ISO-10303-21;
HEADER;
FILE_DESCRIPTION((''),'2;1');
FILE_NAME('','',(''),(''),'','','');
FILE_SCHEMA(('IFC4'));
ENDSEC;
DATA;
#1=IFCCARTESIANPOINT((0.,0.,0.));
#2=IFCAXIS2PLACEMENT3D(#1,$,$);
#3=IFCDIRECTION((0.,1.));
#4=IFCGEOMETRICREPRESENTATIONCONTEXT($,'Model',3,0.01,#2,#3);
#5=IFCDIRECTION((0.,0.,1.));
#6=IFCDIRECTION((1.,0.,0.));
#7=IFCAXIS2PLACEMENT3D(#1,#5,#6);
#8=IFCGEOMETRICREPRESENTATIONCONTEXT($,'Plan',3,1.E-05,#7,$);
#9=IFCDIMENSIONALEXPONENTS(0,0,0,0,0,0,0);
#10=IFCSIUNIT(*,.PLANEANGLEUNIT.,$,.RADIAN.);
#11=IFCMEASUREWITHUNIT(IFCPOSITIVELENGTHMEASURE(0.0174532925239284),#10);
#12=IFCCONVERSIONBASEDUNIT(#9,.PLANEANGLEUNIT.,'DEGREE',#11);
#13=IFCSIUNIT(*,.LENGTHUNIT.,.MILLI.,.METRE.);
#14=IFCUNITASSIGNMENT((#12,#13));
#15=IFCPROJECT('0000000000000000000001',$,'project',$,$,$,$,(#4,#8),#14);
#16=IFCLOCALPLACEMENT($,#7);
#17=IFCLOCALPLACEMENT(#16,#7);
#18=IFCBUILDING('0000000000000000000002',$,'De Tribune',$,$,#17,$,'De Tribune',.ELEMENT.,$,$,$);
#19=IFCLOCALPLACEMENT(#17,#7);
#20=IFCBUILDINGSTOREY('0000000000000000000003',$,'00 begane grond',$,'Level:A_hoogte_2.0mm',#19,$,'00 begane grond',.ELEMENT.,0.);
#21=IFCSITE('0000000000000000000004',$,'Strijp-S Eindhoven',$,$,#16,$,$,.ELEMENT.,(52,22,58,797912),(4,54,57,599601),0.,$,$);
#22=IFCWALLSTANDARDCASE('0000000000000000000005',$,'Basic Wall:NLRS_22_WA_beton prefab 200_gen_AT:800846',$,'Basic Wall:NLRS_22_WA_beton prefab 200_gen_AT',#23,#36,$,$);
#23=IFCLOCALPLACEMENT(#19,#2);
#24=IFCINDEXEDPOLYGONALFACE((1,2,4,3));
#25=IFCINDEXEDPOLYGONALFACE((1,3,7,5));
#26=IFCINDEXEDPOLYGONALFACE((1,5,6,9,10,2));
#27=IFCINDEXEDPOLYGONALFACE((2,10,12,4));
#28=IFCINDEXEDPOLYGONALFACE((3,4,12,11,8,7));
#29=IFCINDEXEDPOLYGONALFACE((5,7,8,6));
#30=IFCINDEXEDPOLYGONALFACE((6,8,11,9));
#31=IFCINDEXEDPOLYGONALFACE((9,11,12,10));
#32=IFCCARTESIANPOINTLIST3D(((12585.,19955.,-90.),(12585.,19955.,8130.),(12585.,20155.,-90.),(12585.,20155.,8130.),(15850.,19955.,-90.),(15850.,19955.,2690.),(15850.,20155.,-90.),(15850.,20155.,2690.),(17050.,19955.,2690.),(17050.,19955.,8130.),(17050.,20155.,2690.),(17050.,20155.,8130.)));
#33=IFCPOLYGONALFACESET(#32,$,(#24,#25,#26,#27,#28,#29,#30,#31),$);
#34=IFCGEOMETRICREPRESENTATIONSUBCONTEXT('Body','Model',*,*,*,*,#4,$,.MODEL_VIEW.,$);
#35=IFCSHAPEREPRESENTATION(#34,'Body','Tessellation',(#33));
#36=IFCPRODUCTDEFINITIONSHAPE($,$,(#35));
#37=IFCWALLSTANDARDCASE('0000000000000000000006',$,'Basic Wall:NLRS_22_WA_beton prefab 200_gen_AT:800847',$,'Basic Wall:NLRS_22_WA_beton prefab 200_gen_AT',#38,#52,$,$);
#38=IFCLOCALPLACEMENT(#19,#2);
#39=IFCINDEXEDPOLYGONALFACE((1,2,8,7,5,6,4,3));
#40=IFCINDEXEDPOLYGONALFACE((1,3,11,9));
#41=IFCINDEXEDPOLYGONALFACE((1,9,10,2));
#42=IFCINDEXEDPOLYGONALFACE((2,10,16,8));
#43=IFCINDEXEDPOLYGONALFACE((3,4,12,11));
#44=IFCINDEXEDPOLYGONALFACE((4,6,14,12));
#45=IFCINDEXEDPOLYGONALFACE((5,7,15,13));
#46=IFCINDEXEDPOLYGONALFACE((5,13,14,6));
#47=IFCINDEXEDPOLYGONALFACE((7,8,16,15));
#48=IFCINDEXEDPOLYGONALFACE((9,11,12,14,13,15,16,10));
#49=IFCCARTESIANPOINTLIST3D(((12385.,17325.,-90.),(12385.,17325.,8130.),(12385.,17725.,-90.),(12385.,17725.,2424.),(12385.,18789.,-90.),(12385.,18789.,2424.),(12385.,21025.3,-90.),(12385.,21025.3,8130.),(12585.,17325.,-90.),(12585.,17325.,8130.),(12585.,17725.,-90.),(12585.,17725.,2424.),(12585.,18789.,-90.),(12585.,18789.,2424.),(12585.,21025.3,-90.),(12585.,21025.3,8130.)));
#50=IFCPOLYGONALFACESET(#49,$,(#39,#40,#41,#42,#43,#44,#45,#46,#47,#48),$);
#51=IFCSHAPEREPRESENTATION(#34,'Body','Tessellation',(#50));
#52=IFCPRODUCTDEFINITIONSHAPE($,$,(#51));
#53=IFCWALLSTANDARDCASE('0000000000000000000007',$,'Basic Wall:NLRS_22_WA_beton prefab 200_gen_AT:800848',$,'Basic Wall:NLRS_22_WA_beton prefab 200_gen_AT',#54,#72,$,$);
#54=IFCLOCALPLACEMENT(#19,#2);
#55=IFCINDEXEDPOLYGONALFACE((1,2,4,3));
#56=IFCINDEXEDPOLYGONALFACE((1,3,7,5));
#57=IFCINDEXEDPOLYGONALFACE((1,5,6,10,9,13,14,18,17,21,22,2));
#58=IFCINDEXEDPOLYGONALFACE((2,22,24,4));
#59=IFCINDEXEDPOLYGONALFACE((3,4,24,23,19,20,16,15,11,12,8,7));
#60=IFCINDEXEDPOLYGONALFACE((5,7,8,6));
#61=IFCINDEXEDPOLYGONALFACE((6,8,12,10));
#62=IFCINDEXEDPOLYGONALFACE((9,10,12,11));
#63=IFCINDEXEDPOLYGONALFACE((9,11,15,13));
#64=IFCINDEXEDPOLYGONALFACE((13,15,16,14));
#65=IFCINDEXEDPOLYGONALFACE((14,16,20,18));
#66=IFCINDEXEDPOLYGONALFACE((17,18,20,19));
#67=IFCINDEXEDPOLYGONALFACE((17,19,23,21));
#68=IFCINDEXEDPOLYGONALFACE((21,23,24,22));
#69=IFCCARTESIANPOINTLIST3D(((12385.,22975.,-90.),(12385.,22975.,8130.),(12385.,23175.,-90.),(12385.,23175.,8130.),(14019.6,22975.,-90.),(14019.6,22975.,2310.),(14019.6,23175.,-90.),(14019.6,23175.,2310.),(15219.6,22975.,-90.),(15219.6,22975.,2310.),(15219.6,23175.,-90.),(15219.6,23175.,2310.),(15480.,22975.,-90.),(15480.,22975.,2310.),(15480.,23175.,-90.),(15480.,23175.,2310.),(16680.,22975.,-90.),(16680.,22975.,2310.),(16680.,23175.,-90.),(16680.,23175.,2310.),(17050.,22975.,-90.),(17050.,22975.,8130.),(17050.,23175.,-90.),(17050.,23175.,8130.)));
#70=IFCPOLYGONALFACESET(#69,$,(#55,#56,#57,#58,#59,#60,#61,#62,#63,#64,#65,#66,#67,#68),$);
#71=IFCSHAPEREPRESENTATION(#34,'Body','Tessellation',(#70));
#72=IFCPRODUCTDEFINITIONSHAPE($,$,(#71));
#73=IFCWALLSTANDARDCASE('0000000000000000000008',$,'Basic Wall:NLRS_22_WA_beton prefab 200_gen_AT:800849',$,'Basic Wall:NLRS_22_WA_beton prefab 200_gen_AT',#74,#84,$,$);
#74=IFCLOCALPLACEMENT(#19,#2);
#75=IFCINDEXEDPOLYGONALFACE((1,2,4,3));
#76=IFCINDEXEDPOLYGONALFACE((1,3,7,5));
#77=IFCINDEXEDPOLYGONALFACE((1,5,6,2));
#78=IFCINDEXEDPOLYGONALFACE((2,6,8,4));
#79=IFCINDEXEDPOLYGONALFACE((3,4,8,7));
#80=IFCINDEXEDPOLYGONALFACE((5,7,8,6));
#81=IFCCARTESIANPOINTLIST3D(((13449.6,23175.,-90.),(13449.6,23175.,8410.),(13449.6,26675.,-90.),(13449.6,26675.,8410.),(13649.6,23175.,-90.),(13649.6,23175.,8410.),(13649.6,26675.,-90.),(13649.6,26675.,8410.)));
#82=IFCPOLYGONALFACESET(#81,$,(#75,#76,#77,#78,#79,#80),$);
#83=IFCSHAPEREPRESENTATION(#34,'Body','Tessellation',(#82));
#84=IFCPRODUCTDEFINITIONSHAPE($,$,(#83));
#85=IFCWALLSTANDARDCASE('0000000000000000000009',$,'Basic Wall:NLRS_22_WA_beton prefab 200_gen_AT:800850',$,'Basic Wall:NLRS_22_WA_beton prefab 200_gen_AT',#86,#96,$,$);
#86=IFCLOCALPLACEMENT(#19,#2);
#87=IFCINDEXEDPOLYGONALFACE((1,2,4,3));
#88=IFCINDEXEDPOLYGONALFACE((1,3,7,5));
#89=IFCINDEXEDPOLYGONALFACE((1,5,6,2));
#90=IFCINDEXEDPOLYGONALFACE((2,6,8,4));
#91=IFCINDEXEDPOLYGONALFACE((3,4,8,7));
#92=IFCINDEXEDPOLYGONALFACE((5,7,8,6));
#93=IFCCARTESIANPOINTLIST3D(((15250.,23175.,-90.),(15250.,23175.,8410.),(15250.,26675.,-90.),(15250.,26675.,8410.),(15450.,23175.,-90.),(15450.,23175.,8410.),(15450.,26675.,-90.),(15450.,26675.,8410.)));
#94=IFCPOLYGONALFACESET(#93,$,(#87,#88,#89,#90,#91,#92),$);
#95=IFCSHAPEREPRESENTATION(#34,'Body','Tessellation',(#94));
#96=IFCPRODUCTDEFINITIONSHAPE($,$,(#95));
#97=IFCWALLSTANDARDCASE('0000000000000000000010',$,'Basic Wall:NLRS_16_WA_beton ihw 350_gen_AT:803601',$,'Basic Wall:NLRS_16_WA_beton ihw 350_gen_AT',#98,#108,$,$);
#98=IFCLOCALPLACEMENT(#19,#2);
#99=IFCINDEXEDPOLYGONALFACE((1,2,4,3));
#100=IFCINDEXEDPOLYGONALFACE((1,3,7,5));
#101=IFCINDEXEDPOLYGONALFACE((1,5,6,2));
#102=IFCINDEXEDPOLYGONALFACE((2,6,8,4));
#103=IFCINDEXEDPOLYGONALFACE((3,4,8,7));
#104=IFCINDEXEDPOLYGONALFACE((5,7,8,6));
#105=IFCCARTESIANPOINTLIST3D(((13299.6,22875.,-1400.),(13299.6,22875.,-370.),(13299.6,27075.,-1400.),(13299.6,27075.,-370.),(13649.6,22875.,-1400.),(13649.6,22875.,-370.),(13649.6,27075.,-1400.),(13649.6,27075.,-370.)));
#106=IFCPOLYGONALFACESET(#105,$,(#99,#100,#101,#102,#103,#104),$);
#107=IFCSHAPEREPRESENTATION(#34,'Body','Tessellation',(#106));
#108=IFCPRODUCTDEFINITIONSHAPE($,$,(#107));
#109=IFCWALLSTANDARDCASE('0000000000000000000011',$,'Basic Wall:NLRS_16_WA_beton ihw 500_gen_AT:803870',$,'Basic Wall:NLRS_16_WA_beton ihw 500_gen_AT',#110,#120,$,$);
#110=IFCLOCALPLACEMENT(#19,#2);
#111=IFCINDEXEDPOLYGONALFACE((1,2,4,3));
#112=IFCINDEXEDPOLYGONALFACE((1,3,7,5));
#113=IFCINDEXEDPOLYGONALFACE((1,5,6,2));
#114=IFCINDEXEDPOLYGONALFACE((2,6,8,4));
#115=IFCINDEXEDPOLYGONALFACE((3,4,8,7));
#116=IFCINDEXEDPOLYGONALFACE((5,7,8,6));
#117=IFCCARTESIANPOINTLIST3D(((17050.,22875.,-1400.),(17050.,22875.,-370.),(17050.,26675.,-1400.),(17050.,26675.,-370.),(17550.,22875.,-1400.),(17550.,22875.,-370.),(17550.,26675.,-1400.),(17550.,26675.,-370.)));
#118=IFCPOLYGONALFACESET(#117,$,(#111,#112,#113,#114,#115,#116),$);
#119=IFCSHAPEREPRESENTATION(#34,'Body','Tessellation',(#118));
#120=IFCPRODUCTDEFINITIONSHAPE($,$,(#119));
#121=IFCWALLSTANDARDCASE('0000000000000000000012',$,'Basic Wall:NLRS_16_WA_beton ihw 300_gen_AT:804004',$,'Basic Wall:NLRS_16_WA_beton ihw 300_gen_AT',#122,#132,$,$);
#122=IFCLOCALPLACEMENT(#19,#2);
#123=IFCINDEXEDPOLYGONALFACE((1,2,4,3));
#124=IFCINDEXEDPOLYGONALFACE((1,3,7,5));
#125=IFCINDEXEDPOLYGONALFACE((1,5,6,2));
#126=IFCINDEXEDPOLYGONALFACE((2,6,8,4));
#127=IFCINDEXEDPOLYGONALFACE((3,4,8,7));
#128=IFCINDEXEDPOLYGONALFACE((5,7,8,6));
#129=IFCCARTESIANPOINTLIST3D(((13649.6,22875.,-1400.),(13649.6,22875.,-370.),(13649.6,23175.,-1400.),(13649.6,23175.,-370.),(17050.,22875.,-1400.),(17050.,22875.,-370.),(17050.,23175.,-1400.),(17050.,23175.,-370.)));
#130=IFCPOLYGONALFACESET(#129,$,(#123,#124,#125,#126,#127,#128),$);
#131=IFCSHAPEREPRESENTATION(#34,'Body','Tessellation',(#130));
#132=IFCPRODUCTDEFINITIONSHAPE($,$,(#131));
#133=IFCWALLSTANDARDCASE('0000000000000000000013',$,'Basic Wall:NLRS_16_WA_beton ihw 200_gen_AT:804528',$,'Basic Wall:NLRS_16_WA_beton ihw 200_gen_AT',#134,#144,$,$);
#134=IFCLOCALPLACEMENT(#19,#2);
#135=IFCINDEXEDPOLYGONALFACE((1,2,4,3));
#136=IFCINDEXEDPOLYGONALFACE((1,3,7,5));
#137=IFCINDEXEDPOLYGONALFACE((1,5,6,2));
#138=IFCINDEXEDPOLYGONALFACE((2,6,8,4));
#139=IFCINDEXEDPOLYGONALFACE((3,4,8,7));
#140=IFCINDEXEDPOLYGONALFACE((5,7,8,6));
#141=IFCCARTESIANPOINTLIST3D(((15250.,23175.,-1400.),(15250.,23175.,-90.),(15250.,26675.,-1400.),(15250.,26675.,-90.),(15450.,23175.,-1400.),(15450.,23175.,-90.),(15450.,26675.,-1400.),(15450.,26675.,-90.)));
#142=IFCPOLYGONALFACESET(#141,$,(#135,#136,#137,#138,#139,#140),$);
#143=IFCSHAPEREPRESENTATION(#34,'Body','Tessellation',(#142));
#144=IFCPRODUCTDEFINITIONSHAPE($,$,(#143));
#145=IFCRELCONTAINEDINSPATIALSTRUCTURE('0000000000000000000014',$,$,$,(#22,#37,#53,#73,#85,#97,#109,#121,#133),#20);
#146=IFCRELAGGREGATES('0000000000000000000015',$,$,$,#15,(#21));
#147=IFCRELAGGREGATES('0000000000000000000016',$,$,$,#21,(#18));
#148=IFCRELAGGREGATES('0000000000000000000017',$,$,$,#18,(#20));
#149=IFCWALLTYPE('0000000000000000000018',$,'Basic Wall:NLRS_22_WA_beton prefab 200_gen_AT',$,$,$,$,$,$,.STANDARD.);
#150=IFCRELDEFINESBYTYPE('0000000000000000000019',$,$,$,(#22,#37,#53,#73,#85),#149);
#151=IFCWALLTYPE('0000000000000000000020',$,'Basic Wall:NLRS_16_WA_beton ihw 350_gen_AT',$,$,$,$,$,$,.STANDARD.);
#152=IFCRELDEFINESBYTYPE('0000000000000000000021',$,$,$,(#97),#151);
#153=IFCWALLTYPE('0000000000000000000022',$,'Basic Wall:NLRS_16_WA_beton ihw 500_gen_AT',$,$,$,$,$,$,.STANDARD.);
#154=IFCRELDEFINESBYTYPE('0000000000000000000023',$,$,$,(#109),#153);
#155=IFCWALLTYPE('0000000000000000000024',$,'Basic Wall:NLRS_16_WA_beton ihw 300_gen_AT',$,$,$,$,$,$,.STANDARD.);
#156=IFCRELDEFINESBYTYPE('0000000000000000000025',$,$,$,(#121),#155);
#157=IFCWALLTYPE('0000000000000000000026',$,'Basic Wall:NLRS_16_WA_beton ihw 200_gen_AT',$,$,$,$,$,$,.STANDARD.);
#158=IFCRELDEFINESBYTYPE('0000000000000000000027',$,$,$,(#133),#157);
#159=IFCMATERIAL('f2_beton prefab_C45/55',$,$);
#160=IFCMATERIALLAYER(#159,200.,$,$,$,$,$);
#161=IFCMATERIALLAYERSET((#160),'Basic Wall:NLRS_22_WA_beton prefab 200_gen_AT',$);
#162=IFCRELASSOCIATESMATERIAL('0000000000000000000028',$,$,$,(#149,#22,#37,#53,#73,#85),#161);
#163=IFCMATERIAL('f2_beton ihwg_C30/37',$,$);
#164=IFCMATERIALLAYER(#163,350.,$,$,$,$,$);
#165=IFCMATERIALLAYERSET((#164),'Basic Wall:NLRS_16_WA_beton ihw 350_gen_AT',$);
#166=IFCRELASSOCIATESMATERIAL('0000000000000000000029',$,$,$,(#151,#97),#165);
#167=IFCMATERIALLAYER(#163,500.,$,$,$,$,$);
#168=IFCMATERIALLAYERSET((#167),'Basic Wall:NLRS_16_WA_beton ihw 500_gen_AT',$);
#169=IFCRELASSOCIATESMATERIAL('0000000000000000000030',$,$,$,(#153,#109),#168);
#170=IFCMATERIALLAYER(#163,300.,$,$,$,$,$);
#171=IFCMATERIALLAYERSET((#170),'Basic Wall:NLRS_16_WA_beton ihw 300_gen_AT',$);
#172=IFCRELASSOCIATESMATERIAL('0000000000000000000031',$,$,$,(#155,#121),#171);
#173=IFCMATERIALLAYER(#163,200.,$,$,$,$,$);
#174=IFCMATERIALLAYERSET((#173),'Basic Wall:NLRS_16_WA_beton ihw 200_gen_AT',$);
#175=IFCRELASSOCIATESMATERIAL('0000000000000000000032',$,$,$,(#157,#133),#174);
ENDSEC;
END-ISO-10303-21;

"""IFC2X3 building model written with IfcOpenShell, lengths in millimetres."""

from ifc_helpers import new_model, entity, si_unit, converted_unit, direction, frame, frame_2d, origin, origin_with_axes, origin_2d_with_axis, place, context, subcontext, project, spatial, rectangle, extrude, material, layer, layer_set, layer_usage, type_object, element, save


model = new_model("IFC2X3")

# Units and contexts
model_context = context("Model", 3, precision=0.01, world=origin(), true_north=direction((0.0, 1.0)))
plan_context = context("Plan", 3, precision=1e-05, world=origin_with_axes())
body_context = subcontext(model_context, "Body", "Model", "MODEL_VIEW")
ifc_project = project(units=[converted_unit("PLANEANGLEUNIT", "DEGREE", entity("IfcPositiveLengthMeasure", 0.0174532925239284), si_unit("PLANEANGLEUNIT", "RADIAN"), dimensions=[0, 0, 0, 0, 0, 0, 0]), si_unit("LENGTHUNIT", "METRE", prefix="MILLI")], contexts=[model_context, plan_context])

# Site, building, storey
site_placement = place(None, origin_with_axes())
site = spatial("IfcSite", under=ifc_project, at=site_placement, Name="Strijp-S Eindhoven", CompositionType="ELEMENT", RefLatitude=(52, 22, 58, 797912), RefLongitude=(4, 54, 57, 599601), RefElevation=0.0)
building_placement = place(site_placement, origin_with_axes())
building = spatial("IfcBuilding", under=site, at=building_placement, Name="De Tribune", LongName="De Tribune", CompositionType="ELEMENT")
storey_placement = place(building_placement, origin_with_axes())
storey = spatial("IfcBuildingStorey", under=building, at=storey_placement, Name="00 begane grond", ObjectType="Level:A_hoogte_2.0mm", LongName="00 begane grond", CompositionType="ELEMENT", Elevation=0.0)

# Shared definitions
ifc_material_1 = material(Name="f2_beton ihwg_C30/37")

# Walls, openings
ifc_material_2 = material(Name="f2_beton prefab_C45/55")
ifc_layer_1 = layer(ifc_material_2, 200.0)
ifc_layer_set_1 = layer_set([ifc_layer_1], Name="Basic Wall:NLRS_22_WA_beton prefab 200_gen_AT")
ifc_layer_usage_1 = layer_usage(ifc_layer_set_1, "AXIS2", "POSITIVE", -100.0)
wall_type_1 = type_object("IfcWallType", Name="Basic Wall:NLRS_22_WA_beton prefab 200_gen_AT", PredefinedType="STANDARD", material=ifc_layer_set_1)
wall_1_placement = place(storey_placement, frame((12585.0, 20055.0, -90.0), z_axis=(0.0, 0.0, 1.0), x_axis=(1.0, 0.0, 0.0)))
wall_1 = element("IfcWallStandardCase", 1, at=wall_1_placement, inside=storey, type_object=wall_type_1, material=ifc_layer_usage_1, Name="Basic Wall:NLRS_22_WA_beton prefab 200_gen_AT:800846", ObjectType="Basic Wall:NLRS_22_WA_beton prefab 200_gen_AT", context=body_context, shape_type="SweptSolid", body=[
    extrude(rectangle(XDim=4465.0, YDim=200.0, at=frame_2d((2232.5, 0.0), x_axis=(-1.0, 0.0))), origin(), (0.0, 0.0, 1.0), 8220.0),
])
opening_1_placement = place(wall_1_placement, frame((-12585.0, -20055.0, 90.0), z_axis=(0.0, 0.0, 1.0), x_axis=(1.0, 0.0, 0.0)))
element("IfcOpeningElement", 2, at=opening_1_placement, cuts=wall_1, ObjectType="Opening", context=body_context, shape_type="SweptSolid", body=[
    extrude(rectangle(XDim=2780.0, YDim=1200.0, at=origin_2d_with_axis()), frame((16450.0, 18431.0, 1300.0), z_axis=(0.0, 1.0, 0.0), x_axis=(0.0, 0.0, -1.0)), (0.0, 0.0, 1.0), 3048.0),
])
ifc_layer_usage_2 = layer_usage(ifc_layer_set_1, "AXIS2", "NEGATIVE", 100.0)
wall_2_placement = place(storey_placement, frame((12485.0, 21025.3, -90.0), z_axis=(0.0, 0.0, 1.0), x_axis=(0.0, -1.0, 0.0)))
wall_2 = element("IfcWallStandardCase", 3, at=wall_2_placement, inside=storey, type_object=wall_type_1, material=ifc_layer_usage_2, Name="Basic Wall:NLRS_22_WA_beton prefab 200_gen_AT:800847", ObjectType="Basic Wall:NLRS_22_WA_beton prefab 200_gen_AT", context=body_context, shape_type="SweptSolid", body=[
    extrude(rectangle(XDim=3700.3, YDim=200.0, at=frame_2d((1850.1, 0.0), x_axis=(1.0, 0.0))), origin(), (0.0, 0.0, 1.0), 8220.0),
])
opening_2_placement = place(wall_2_placement, frame((21025.3, -12485.0, 90.0), z_axis=(0.0, 0.0, 1.0), x_axis=(0.0, 1.0, 0.0)))
element("IfcOpeningElement", 4, at=opening_2_placement, cuts=wall_2, ObjectType="Opening", context=body_context, shape_type="SweptSolid", body=[
    extrude(rectangle(XDim=2514.0, YDim=1064.0, at=frame_2d((0.0, 0.0), x_axis=(0.0, 1.0))), frame((10861.0, 18257.0, 1167.0), z_axis=(1.0, 0.0, 0.0), x_axis=(0.0, -1.0, 0.0)), (0.0, 0.0, 1.0), 3048.0),
])

# Wall, openings
ifc_layer_usage_3 = layer_usage(ifc_layer_set_1, "AXIS2", "POSITIVE", -100.0)
wall_3_placement = place(storey_placement, frame((12385.0, 23075.0, -90.0), z_axis=(0.0, 0.0, 1.0), x_axis=(1.0, 0.0, 0.0)))
wall_3 = element("IfcWallStandardCase", 5, at=wall_3_placement, inside=storey, type_object=wall_type_1, material=ifc_layer_usage_3, Name="Basic Wall:NLRS_22_WA_beton prefab 200_gen_AT:800848", ObjectType="Basic Wall:NLRS_22_WA_beton prefab 200_gen_AT", context=body_context, shape_type="SweptSolid", body=[
    extrude(rectangle(XDim=4665.0, YDim=200.0, at=frame_2d((2332.5, 0.0), x_axis=(1.0, 0.0))), origin(), (0.0, 0.0, 1.0), 8220.0),
])
opening_3_placement = place(wall_3_placement, frame((-12385.0, -23075.0, 90.0), z_axis=(0.0, 0.0, 1.0), x_axis=(1.0, 0.0, 0.0)))
element("IfcOpeningElement", 6, at=opening_3_placement, cuts=wall_3, ObjectType="Opening", context=body_context, shape_type="SweptSolid", body=[
    extrude(rectangle(XDim=2400.0, YDim=1200.0, at=frame_2d((0.0, 0.0), x_axis=(0.0, 1.0))), frame((16080.0, 21651.0, 1110.0), z_axis=(0.0, 1.0, 0.0), x_axis=(1.0, 0.0, 0.0)), (0.0, 0.0, 1.0), 3048.0),
])
opening_4_placement = place(wall_3_placement, frame((-12385.0, -23075.0, 90.0), z_axis=(0.0, 0.0, 1.0), x_axis=(1.0, 0.0, 0.0)))
element("IfcOpeningElement", 7, at=opening_4_placement, cuts=wall_3, ObjectType="Opening", context=body_context, shape_type="SweptSolid", body=[
    extrude(rectangle(XDim=2400.0, YDim=1200.0, at=frame_2d((0.0, 0.0), x_axis=(0.0, 1.0))), frame((14619.6, 21651.0, 1110.0), z_axis=(0.0, 1.0, 0.0), x_axis=(1.0, 0.0, 0.0)), (0.0, 0.0, 1.0), 3048.0),
])

# Walls
ifc_layer_usage_4 = layer_usage(ifc_layer_set_1, "AXIS2", "NEGATIVE", 100.0)
wall_4_placement = place(storey_placement, frame((13549.6, 26675.0, -90.0), z_axis=(0.0, 0.0, 1.0), x_axis=(0.0, -1.0, 0.0)))
element("IfcWallStandardCase", 8, at=wall_4_placement, inside=storey, type_object=wall_type_1, material=ifc_layer_usage_4, Name="Basic Wall:NLRS_22_WA_beton prefab 200_gen_AT:800849", ObjectType="Basic Wall:NLRS_22_WA_beton prefab 200_gen_AT", context=body_context, shape_type="SweptSolid", body=[
    extrude(rectangle(XDim=3500.0, YDim=200.0, at=frame_2d((1750.0, 0.0), x_axis=(-1.0, 0.0))), origin(), (0.0, 0.0, 1.0), 8500.0),
])
ifc_layer_usage_5 = layer_usage(ifc_layer_set_1, "AXIS2", "NEGATIVE", 100.0)
wall_5_placement = place(storey_placement, frame((15350.0, 26675.0, -90.0), z_axis=(0.0, 0.0, 1.0), x_axis=(0.0, -1.0, 0.0)))
element("IfcWallStandardCase", 9, at=wall_5_placement, inside=storey, type_object=wall_type_1, material=ifc_layer_usage_5, Name="Basic Wall:NLRS_22_WA_beton prefab 200_gen_AT:800850", ObjectType="Basic Wall:NLRS_22_WA_beton prefab 200_gen_AT", context=body_context, shape_type="SweptSolid", body=[
    extrude(rectangle(XDim=3500.0, YDim=200.0, at=frame_2d((1750.0, 0.0), x_axis=(-1.0, 0.0))), origin(), (0.0, 0.0, 1.0), 8500.0),
])
ifc_layer_2 = layer(ifc_material_1, 350.0)
ifc_layer_set_2 = layer_set([ifc_layer_2], Name="Basic Wall:NLRS_16_WA_beton ihw 350_gen_AT")
ifc_layer_usage_6 = layer_usage(ifc_layer_set_2, "AXIS2", "NEGATIVE", 175.0)
wall_type_2 = type_object("IfcWallType", Name="Basic Wall:NLRS_16_WA_beton ihw 350_gen_AT", PredefinedType="STANDARD", material=ifc_layer_set_2)
wall_6_placement = place(storey_placement, frame((13474.6, 22875.0, -1400.0), z_axis=(0.0, 0.0, 1.0), x_axis=(0.0, 1.0, 0.0)))
element("IfcWallStandardCase", 10, at=wall_6_placement, inside=storey, type_object=wall_type_2, material=ifc_layer_usage_6, Name="Basic Wall:NLRS_16_WA_beton ihw 350_gen_AT:803601", ObjectType="Basic Wall:NLRS_16_WA_beton ihw 350_gen_AT", context=body_context, shape_type="SweptSolid", body=[
    extrude(rectangle(XDim=4200.0, YDim=350.0, at=frame_2d((2100.0, 0.0), x_axis=(-1.0, 0.0))), origin(), (0.0, 0.0, 1.0), 1030.0),
])
ifc_layer_3 = layer(ifc_material_1, 500.0)
ifc_layer_set_3 = layer_set([ifc_layer_3], Name="Basic Wall:NLRS_16_WA_beton ihw 500_gen_AT")
ifc_layer_usage_7 = layer_usage(ifc_layer_set_3, "AXIS2", "NEGATIVE", 250.0)
wall_type_3 = type_object("IfcWallType", Name="Basic Wall:NLRS_16_WA_beton ihw 500_gen_AT", PredefinedType="STANDARD", material=ifc_layer_set_3)
wall_7_placement = place(storey_placement, frame((17300.0, 26675.0, -1400.0), z_axis=(0.0, 0.0, 1.0), x_axis=(0.0, -1.0, 0.0)))
element("IfcWallStandardCase", 11, at=wall_7_placement, inside=storey, type_object=wall_type_3, material=ifc_layer_usage_7, Name="Basic Wall:NLRS_16_WA_beton ihw 500_gen_AT:803870", ObjectType="Basic Wall:NLRS_16_WA_beton ihw 500_gen_AT", context=body_context, shape_type="SweptSolid", body=[
    extrude(rectangle(XDim=3800.0, YDim=500.0, at=frame_2d((1900.0, 0.0), x_axis=(-1.0, 0.0))), origin(), (0.0, 0.0, 1.0), 1030.0),
])
ifc_layer_4 = layer(ifc_material_1, 300.0)
ifc_layer_set_4 = layer_set([ifc_layer_4], Name="Basic Wall:NLRS_16_WA_beton ihw 300_gen_AT")
ifc_layer_usage_8 = layer_usage(ifc_layer_set_4, "AXIS2", "NEGATIVE", 150.0)
wall_type_4 = type_object("IfcWallType", Name="Basic Wall:NLRS_16_WA_beton ihw 300_gen_AT", PredefinedType="STANDARD", material=ifc_layer_set_4)
wall_8_placement = place(storey_placement, frame((17050.0, 23025.0, -1400.0), z_axis=(0.0, 0.0, 1.0), x_axis=(-1.0, 0.0, 0.0)))
element("IfcWallStandardCase", 12, at=wall_8_placement, inside=storey, type_object=wall_type_4, material=ifc_layer_usage_8, Name="Basic Wall:NLRS_16_WA_beton ihw 300_gen_AT:804004", ObjectType="Basic Wall:NLRS_16_WA_beton ihw 300_gen_AT", context=body_context, shape_type="SweptSolid", body=[
    extrude(rectangle(XDim=3400.4, YDim=300.0, at=frame_2d((1700.2, 0.0), x_axis=(-1.0, 0.0))), origin(), (0.0, 0.0, 1.0), 1030.0),
])
ifc_layer_5 = layer(ifc_material_1, 200.0)
ifc_layer_set_5 = layer_set([ifc_layer_5], Name="Basic Wall:NLRS_16_WA_beton ihw 200_gen_AT")
ifc_layer_usage_9 = layer_usage(ifc_layer_set_5, "AXIS2", "NEGATIVE", 100.0)
wall_type_5 = type_object("IfcWallType", Name="Basic Wall:NLRS_16_WA_beton ihw 200_gen_AT", PredefinedType="STANDARD", material=ifc_layer_set_5)
wall_9_placement = place(storey_placement, frame((15350.0, 23175.0, -1400.0), z_axis=(0.0, 0.0, 1.0), x_axis=(0.0, 1.0, 0.0)))
element("IfcWallStandardCase", 13, at=wall_9_placement, inside=storey, type_object=wall_type_5, material=ifc_layer_usage_9, Name="Basic Wall:NLRS_16_WA_beton ihw 200_gen_AT:804528", ObjectType="Basic Wall:NLRS_16_WA_beton ihw 200_gen_AT", context=body_context, shape_type="SweptSolid", body=[
    extrude(rectangle(XDim=3500.0, YDim=200.0, at=frame_2d((1750.0, 0.0), x_axis=(-1.0, 0.0))), origin(), (0.0, 0.0, 1.0), 1310.0),
])

save(model, "model.ifc")
